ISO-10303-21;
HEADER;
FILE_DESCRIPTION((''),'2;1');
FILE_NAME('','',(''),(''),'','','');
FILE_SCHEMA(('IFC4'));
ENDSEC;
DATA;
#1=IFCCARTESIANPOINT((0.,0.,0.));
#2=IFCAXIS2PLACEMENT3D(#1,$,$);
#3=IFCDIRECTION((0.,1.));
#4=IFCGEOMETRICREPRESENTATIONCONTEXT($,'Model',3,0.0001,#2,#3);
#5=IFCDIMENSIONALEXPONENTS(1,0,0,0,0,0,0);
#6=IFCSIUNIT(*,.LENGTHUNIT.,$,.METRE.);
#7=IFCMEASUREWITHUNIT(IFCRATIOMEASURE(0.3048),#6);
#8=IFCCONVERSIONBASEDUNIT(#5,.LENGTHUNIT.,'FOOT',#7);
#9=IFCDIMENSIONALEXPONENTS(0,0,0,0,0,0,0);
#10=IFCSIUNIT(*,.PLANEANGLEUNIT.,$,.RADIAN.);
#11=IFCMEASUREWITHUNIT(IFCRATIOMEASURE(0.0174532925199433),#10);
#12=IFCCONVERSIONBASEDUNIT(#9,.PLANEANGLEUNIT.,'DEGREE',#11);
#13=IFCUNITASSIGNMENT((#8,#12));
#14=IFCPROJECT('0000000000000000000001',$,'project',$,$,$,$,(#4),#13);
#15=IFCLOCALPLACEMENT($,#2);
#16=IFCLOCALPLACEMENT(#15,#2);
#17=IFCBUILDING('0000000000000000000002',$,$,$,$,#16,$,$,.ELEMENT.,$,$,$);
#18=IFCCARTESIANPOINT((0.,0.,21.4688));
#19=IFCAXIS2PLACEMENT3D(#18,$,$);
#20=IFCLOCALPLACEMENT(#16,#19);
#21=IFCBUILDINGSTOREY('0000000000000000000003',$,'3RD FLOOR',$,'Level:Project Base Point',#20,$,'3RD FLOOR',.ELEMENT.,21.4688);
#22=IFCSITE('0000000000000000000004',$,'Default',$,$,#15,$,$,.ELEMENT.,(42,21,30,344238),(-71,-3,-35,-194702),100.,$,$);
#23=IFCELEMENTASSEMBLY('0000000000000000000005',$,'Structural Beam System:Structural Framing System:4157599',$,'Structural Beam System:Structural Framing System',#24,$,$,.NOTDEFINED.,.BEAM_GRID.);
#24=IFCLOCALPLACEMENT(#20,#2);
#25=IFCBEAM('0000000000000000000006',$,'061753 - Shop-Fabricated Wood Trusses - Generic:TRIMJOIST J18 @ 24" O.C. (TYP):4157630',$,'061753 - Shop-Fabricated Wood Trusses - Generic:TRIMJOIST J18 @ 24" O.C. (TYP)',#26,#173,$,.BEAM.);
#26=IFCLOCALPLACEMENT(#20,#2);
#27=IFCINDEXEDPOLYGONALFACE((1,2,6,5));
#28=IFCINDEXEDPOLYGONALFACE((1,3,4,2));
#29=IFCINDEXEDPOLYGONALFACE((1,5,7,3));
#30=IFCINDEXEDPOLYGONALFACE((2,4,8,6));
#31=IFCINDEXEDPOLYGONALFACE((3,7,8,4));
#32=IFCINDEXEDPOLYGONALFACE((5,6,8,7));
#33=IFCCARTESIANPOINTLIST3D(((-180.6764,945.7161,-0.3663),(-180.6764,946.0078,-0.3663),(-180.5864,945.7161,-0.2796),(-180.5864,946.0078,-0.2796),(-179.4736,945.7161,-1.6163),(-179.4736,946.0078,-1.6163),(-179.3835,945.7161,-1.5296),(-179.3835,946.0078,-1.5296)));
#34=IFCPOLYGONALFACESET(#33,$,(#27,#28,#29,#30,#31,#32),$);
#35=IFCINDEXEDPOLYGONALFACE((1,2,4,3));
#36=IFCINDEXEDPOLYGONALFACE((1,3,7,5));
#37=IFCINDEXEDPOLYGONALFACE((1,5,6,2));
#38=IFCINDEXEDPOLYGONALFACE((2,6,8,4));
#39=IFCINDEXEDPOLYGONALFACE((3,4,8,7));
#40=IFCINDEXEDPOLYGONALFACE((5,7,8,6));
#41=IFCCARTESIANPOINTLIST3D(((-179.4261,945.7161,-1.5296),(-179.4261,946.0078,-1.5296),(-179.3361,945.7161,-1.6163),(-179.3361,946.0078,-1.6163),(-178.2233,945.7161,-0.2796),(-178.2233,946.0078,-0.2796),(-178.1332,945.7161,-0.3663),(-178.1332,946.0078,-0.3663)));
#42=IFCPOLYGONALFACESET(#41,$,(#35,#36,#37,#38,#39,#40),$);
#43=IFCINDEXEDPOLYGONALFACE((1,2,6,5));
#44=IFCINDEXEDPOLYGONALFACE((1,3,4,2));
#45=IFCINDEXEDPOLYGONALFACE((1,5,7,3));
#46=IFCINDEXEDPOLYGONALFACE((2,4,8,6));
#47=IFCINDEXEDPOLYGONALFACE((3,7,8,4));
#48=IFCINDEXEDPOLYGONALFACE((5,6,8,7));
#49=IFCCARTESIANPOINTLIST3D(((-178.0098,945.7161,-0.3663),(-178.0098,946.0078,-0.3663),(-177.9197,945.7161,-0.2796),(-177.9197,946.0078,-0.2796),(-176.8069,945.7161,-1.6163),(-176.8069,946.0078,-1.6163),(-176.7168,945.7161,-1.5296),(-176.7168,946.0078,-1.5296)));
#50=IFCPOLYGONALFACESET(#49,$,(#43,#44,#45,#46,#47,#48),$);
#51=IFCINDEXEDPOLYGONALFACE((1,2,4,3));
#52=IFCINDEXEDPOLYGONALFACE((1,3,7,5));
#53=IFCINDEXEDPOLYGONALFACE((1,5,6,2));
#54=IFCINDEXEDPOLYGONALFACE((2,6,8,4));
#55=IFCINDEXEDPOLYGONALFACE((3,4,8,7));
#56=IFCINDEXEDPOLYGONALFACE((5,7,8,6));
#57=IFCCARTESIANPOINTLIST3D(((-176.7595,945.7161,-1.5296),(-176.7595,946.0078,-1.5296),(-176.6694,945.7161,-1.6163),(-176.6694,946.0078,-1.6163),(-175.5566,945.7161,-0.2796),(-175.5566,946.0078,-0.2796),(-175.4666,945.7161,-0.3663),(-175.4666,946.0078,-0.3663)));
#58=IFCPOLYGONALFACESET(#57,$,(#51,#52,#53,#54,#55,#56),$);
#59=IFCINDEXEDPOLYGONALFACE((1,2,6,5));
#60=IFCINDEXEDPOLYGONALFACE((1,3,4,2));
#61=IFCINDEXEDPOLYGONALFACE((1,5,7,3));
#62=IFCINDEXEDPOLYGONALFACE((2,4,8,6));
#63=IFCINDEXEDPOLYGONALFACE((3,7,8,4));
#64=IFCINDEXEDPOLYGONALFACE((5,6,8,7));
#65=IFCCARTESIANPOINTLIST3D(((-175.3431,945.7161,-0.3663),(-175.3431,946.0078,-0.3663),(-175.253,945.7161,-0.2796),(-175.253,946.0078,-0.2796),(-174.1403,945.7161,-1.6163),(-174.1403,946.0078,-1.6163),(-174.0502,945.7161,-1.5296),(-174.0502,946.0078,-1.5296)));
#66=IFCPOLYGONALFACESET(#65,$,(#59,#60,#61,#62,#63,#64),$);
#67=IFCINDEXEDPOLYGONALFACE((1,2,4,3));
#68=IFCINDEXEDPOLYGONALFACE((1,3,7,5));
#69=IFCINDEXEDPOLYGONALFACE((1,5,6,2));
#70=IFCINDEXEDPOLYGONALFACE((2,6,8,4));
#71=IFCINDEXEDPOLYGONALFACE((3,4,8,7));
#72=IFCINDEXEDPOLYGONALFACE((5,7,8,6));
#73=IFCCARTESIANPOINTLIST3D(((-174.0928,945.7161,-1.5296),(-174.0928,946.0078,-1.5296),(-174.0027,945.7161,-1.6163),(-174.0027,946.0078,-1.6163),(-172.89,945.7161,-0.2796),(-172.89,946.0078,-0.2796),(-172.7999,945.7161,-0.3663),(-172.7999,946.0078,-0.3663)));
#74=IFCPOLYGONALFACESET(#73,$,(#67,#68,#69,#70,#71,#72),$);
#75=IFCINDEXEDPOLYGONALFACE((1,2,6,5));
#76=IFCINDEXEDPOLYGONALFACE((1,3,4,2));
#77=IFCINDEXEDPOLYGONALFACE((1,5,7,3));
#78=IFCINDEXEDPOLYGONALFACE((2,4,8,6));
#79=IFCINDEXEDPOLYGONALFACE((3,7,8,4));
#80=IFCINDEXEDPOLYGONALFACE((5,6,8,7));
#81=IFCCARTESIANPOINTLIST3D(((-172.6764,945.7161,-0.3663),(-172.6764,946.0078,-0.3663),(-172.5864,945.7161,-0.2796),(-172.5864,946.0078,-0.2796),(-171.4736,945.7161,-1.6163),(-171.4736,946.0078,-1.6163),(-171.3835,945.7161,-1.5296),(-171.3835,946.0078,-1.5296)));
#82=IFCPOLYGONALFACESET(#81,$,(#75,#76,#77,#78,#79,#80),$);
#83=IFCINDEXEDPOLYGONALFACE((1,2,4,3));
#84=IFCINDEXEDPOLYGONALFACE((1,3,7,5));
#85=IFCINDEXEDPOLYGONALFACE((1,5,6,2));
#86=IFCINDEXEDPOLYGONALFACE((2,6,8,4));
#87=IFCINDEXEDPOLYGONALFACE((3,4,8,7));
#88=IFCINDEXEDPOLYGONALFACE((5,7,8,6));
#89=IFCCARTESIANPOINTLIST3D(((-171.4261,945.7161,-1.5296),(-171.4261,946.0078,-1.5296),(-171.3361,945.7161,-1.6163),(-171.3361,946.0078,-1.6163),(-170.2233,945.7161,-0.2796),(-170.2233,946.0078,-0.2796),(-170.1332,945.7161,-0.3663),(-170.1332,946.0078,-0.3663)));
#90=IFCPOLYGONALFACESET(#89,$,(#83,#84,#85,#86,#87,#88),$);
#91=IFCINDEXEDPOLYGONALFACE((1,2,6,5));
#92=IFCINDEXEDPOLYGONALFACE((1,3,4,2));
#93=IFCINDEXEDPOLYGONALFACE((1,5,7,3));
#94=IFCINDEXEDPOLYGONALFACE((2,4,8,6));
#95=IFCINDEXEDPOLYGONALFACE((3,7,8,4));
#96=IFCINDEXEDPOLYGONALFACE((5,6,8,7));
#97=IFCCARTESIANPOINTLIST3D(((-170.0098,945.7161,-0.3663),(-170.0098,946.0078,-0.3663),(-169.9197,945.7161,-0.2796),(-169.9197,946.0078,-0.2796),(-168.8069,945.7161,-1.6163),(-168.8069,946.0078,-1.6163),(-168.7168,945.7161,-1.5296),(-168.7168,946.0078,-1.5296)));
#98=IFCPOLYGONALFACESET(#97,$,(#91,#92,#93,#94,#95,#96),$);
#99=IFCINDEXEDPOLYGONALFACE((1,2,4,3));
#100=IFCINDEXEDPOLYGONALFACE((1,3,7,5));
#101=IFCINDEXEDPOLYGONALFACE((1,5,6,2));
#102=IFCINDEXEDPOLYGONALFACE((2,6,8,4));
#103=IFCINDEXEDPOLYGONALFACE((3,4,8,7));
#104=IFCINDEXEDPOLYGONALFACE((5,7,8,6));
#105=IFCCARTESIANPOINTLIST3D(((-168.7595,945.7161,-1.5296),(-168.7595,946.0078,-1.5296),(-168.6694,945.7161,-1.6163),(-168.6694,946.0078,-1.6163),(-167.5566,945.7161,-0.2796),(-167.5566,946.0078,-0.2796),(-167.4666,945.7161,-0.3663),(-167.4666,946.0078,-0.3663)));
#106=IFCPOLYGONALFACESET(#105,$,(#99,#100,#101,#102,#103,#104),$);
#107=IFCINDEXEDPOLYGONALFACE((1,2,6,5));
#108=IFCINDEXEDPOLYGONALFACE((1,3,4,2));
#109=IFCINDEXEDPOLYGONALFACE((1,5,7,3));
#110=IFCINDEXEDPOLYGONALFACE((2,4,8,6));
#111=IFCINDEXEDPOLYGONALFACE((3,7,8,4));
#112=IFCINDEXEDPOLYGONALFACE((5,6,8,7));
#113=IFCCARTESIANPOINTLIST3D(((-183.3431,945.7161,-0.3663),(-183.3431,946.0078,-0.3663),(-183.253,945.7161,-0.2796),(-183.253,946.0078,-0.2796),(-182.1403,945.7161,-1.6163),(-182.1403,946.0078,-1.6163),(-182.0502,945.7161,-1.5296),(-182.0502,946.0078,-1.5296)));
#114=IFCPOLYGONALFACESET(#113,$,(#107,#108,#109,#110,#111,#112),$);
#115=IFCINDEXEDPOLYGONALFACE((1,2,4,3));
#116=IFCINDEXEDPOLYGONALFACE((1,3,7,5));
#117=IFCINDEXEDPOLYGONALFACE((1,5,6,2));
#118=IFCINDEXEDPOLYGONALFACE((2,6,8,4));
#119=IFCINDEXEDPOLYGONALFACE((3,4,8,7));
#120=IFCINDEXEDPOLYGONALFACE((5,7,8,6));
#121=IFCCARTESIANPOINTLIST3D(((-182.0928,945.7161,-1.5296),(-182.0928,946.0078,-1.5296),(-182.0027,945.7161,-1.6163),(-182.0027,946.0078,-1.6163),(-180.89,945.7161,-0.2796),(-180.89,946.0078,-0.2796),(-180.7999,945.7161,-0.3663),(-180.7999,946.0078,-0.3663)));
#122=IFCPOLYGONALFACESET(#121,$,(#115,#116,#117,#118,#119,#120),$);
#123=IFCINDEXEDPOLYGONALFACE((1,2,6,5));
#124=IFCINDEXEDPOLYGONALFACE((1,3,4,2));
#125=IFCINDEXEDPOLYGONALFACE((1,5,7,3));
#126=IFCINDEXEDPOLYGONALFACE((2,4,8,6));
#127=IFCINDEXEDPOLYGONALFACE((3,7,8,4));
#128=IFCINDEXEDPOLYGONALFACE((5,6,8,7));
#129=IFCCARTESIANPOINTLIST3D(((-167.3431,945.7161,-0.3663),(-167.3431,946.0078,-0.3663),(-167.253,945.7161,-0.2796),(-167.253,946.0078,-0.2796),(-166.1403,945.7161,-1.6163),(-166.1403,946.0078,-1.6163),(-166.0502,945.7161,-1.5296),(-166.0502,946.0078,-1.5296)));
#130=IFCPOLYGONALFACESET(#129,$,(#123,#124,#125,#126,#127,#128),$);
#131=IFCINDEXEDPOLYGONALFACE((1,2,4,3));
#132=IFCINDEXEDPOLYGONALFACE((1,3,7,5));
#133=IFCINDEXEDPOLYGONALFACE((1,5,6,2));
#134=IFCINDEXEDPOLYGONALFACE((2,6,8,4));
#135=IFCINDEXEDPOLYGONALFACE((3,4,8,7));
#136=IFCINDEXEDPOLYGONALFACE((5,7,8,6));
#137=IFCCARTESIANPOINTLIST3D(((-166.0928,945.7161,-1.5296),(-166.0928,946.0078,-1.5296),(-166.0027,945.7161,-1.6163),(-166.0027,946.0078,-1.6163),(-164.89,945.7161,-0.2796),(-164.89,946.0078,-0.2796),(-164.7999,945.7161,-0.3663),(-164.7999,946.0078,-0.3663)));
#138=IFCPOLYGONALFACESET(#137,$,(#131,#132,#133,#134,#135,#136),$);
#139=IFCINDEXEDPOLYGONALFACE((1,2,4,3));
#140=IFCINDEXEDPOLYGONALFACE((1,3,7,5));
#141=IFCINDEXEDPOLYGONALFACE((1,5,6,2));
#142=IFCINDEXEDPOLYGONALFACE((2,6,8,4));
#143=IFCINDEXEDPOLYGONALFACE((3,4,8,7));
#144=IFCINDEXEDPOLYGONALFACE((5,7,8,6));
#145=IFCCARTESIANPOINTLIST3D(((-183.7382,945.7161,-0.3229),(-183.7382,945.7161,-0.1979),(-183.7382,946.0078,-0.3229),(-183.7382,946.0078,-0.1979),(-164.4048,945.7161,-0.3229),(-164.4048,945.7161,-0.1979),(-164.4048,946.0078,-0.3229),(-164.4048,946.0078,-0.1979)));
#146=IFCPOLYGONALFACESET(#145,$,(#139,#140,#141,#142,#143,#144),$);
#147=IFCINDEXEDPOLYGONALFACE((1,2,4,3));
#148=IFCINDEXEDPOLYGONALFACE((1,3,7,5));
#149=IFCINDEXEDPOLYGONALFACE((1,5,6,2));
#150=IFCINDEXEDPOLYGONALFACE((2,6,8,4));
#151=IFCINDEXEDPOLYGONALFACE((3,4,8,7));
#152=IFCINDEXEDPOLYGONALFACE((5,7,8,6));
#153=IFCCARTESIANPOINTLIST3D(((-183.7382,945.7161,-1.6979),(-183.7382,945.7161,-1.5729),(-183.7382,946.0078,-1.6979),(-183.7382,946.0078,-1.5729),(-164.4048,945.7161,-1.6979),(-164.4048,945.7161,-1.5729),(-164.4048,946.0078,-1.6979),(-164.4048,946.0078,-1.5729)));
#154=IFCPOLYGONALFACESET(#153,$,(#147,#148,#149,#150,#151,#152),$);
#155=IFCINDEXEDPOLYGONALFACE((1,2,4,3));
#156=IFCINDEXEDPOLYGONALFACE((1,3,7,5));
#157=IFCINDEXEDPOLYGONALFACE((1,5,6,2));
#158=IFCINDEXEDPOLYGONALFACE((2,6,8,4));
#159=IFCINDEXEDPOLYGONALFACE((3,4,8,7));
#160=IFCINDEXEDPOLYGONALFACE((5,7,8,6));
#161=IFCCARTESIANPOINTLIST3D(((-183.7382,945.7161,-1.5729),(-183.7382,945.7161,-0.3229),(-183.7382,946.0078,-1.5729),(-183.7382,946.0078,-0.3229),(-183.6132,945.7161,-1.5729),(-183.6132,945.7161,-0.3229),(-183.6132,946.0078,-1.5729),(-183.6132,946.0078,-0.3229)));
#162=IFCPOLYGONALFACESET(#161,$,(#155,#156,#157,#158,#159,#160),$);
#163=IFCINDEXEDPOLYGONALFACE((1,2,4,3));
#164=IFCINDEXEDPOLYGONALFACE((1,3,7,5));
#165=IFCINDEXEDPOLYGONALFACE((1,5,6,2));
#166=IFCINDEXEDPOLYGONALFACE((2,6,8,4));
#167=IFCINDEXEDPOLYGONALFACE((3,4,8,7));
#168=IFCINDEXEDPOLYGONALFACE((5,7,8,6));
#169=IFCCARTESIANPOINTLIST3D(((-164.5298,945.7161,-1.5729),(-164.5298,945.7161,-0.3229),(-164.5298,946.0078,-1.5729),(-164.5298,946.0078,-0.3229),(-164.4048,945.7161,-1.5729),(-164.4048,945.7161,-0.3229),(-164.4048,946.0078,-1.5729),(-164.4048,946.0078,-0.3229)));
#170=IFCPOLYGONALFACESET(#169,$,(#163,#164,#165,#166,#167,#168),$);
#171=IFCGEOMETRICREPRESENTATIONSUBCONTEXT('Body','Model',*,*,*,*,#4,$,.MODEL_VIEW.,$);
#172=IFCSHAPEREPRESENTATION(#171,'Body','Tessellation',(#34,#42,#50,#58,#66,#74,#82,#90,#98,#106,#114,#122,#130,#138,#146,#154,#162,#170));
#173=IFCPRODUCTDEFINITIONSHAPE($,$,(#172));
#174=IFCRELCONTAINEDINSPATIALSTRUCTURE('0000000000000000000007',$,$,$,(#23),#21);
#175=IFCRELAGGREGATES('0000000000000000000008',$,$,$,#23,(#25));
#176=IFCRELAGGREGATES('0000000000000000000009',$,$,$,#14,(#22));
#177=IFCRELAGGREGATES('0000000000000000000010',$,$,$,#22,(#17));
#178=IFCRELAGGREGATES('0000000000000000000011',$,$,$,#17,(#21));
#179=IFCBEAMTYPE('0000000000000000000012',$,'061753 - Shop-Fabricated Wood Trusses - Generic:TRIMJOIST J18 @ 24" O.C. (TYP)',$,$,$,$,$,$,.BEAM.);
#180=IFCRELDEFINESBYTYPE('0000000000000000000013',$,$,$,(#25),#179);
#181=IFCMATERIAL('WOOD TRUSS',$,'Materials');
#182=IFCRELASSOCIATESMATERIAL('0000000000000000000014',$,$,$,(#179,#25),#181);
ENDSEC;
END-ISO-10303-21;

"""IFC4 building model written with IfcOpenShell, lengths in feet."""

from ifc_helpers import new_model, entity, si_unit, converted_unit, direction, frame, frame_2d, origin, origin_2d_with_axis, place, context, subcontext, project, spatial, rectangle, extrude, source, transform, mapped, material, material_profile, profile_set, profile_usage, type_object, type_shapes, element, aggregate, save


model = new_model("IFC4")

# Units and contexts
model_context = context("Model", 3, precision=0.0001, world=origin(), true_north=direction((0.0, 1.0)))
body_context = subcontext(model_context, "Body", "Model", "MODEL_VIEW")
ifc_project = project(units=[converted_unit("LENGTHUNIT", "FOOT", entity("IfcRatioMeasure", 0.3048), si_unit("LENGTHUNIT", "METRE"), dimensions=[1, 0, 0, 0, 0, 0, 0]), converted_unit("PLANEANGLEUNIT", "DEGREE", entity("IfcRatioMeasure", 0.0174532925199433), si_unit("PLANEANGLEUNIT", "RADIAN"), dimensions=[0, 0, 0, 0, 0, 0, 0])], contexts=[model_context])

# Site, building, storey
site_placement = place(None, origin())
site = spatial("IfcSite", under=ifc_project, at=site_placement, Name="Default", CompositionType="ELEMENT", RefLatitude=(42, 21, 30, 344238), RefLongitude=(-71, -3, -35, -194702), RefElevation=100.0)
building_placement = place(site_placement, origin())
building = spatial("IfcBuilding", under=site, at=building_placement, CompositionType="ELEMENT")
storey_placement = place(building_placement, frame((0.0, 0.0, 21.4688)))
storey = spatial("IfcBuildingStorey", under=building, at=storey_placement, Name="3RD FLOOR", ObjectType="Level:Project Base Point", LongName="3RD FLOOR", CompositionType="ELEMENT", Elevation=21.4688)

# Element assembly, beam
ifc_material = material(Name="WOOD TRUSS", Category="Materials")
ifc_material_profile_1 = material_profile(ifc_material, rectangle(XDim=1.7347, YDim=0.125, at=frame_2d((0.0, 0.0), x_axis=(1.0, 0.0))), Name="TRIMJOIST J18 @ 24\" O.C. (TYP)")
ifc_material_profile_2 = material_profile(ifc_material, rectangle(XDim=1.7347, YDim=0.125, at=frame_2d((0.0, 0.0), x_axis=(1.0, 0.0))), Name="TRIMJOIST J18 @ 24\" O.C. (TYP)")
ifc_material_profile_3 = material_profile(ifc_material, rectangle(XDim=1.7347, YDim=0.125, at=frame_2d((0.0, 0.0), x_axis=(1.0, 0.0))), Name="TRIMJOIST J18 @ 24\" O.C. (TYP)")
ifc_material_profile_4 = material_profile(ifc_material, rectangle(XDim=1.7347, YDim=0.125, at=frame_2d((0.0, 0.0), x_axis=(1.0, 0.0))), Name="TRIMJOIST J18 @ 24\" O.C. (TYP)")
ifc_material_profile_5 = material_profile(ifc_material, rectangle(XDim=1.7347, YDim=0.125, at=frame_2d((0.0, 0.0), x_axis=(1.0, 0.0))), Name="TRIMJOIST J18 @ 24\" O.C. (TYP)")
ifc_material_profile_6 = material_profile(ifc_material, rectangle(XDim=1.7347, YDim=0.125, at=frame_2d((0.0, 0.0), x_axis=(1.0, 0.0))), Name="TRIMJOIST J18 @ 24\" O.C. (TYP)")
ifc_material_profile_7 = material_profile(ifc_material, rectangle(XDim=1.7347, YDim=0.125, at=frame_2d((0.0, 0.0), x_axis=(1.0, 0.0))), Name="TRIMJOIST J18 @ 24\" O.C. (TYP)")
ifc_material_profile_8 = material_profile(ifc_material, rectangle(XDim=1.7347, YDim=0.125, at=frame_2d((0.0, 0.0), x_axis=(1.0, 0.0))), Name="TRIMJOIST J18 @ 24\" O.C. (TYP)")
ifc_material_profile_9 = material_profile(ifc_material, rectangle(XDim=1.7347, YDim=0.125, at=frame_2d((0.0, 0.0), x_axis=(1.0, 0.0))), Name="TRIMJOIST J18 @ 24\" O.C. (TYP)")
ifc_material_profile_10 = material_profile(ifc_material, rectangle(XDim=1.7347, YDim=0.125, at=origin_2d_with_axis()), Name="TRIMJOIST J18 @ 24\" O.C. (TYP)")
ifc_material_profile_11 = material_profile(ifc_material, rectangle(XDim=0.125, YDim=0.2917, at=origin_2d_with_axis()), Name="TRIMJOIST J18 @ 24\" O.C. (TYP)")
ifc_material_profile_12 = material_profile(ifc_material, rectangle(XDim=0.125, YDim=0.2917, at=origin_2d_with_axis()), Name="TRIMJOIST J18 @ 24\" O.C. (TYP)")
ifc_material_profile_13 = material_profile(ifc_material, rectangle(XDim=1.25, YDim=0.2917, at=origin_2d_with_axis()), Name="TRIMJOIST J18 @ 24\" O.C. (TYP)")
ifc_material_profile_14 = material_profile(ifc_material, rectangle(XDim=1.25, YDim=0.2917, at=origin_2d_with_axis()), Name="TRIMJOIST J18 @ 24\" O.C. (TYP)")
ifc_profile_set = profile_set([ifc_material_profile_1, ifc_material_profile_2, ifc_material_profile_3, ifc_material_profile_4, ifc_material_profile_5, ifc_material_profile_6, ifc_material_profile_7, ifc_material_profile_8, ifc_material_profile_9, ifc_material_profile_10, ifc_material_profile_11, ifc_material_profile_12, ifc_material_profile_13, ifc_material_profile_14], Name="TRIMJOIST J18 @ 24\" O.C. (TYP)")
assembly_1_placement = place(storey_placement, origin())
assembly_1 = element("IfcElementAssembly", 1, at=assembly_1_placement, inside=storey, Name="Structural Beam System:Structural Framing System:4157599", ObjectType="Structural Beam System:Structural Framing System", AssemblyPlace="NOTDEFINED", PredefinedType="BEAM_GRID")
beam_type_1 = type_object("IfcBeamType", Name="061753 - Shop-Fabricated Wood Trusses - Generic:TRIMJOIST J18 @ 24\" O.C. (TYP)", PredefinedType="BEAM", material=ifc_profile_set)
shared_shape_1 = source(origin(), body_context, "Body", "SweptSolid", [
    extrude(rectangle(XDim=1.7347, YDim=0.125, at=frame_2d((0.0, 0.0), x_axis=(1.0, 0.0))), frame((5.9585, -0.1458, 0.0), z_axis=(0.0, 1.0, 0.0), x_axis=(0.693383, 0.0, 0.720569)), (0.0, 0.0, 1.0), 0.2917),
    extrude(rectangle(XDim=1.7347, YDim=0.125, at=origin_2d_with_axis()), frame((4.7082, -0.1458, 0.0), z_axis=(0.0, 1.0, 0.0), x_axis=(0.693383, 0.0, -0.720569)), (0.0, 0.0, 1.0), 0.2917),
    extrude(rectangle(XDim=1.7347, YDim=0.125, at=frame_2d((0.0, 0.0), x_axis=(1.0, 0.0))), frame((3.2918, -0.1458, 0.0), z_axis=(0.0, 1.0, 0.0), x_axis=(0.693383, 0.0, 0.720569)), (0.0, 0.0, 1.0), 0.2917),
    extrude(rectangle(XDim=1.7347, YDim=0.125, at=frame_2d((0.0, 0.0), x_axis=(1.0, 0.0))), frame((2.0415, -0.1458, 0.0), z_axis=(0.0, 1.0, 0.0), x_axis=(0.693383, 0.0, -0.720569)), (0.0, 0.0, 1.0), 0.2917),
    extrude(rectangle(XDim=1.7347, YDim=0.125, at=frame_2d((0.0, 0.0), x_axis=(1.0, 0.0))), frame((0.6251, -0.1458, 0.0), z_axis=(0.0, 1.0, 0.0), x_axis=(0.693383, 0.0, 0.720569)), (0.0, 0.0, 1.0), 0.2917),
    extrude(rectangle(XDim=1.7347, YDim=0.125, at=frame_2d((0.0, 0.0), x_axis=(1.0, 0.0))), frame((-0.6251, -0.1458, 0.0), z_axis=(0.0, 1.0, 0.0), x_axis=(0.693383, 0.0, -0.720569)), (0.0, 0.0, 1.0), 0.2917),
    extrude(rectangle(XDim=1.7347, YDim=0.125, at=frame_2d((0.0, 0.0), x_axis=(1.0, 0.0))), frame((-2.0415, -0.1458, 0.0), z_axis=(0.0, 1.0, 0.0), x_axis=(0.693383, 0.0, 0.720569)), (0.0, 0.0, 1.0), 0.2917),
    extrude(rectangle(XDim=1.7347, YDim=0.125, at=origin_2d_with_axis()), frame((-3.2918, -0.1458, 0.0), z_axis=(0.0, 1.0, 0.0), x_axis=(0.693383, 0.0, -0.720569)), (0.0, 0.0, 1.0), 0.2917),
    extrude(rectangle(XDim=1.7347, YDim=0.125, at=frame_2d((0.0, 0.0), x_axis=(1.0, 0.0))), frame((-4.7082, -0.1458, 0.0), z_axis=(0.0, 1.0, 0.0), x_axis=(0.693383, 0.0, 0.720569)), (0.0, 0.0, 1.0), 0.2917),
    extrude(rectangle(XDim=1.7347, YDim=0.125, at=frame_2d((0.0, 0.0), x_axis=(1.0, 0.0))), frame((-5.9585, -0.1458, 0.0), z_axis=(0.0, 1.0, 0.0), x_axis=(0.693383, 0.0, -0.720569)), (0.0, 0.0, 1.0), 0.2917),
    extrude(rectangle(XDim=1.7347, YDim=0.125, at=frame_2d((0.0, 0.0), x_axis=(1.0, 0.0))), frame((8.6251, -0.1458, 0.0), z_axis=(0.0, 1.0, 0.0), x_axis=(0.693383, 0.0, 0.720569)), (0.0, 0.0, 1.0), 0.2917),
    extrude(rectangle(XDim=1.7347, YDim=0.125, at=origin_2d_with_axis()), frame((7.3749, -0.1458, 0.0), z_axis=(0.0, 1.0, 0.0), x_axis=(0.693383, 0.0, -0.720569)), (0.0, 0.0, 1.0), 0.2917),
    extrude(rectangle(XDim=1.7347, YDim=0.125, at=frame_2d((0.0, 0.0), x_axis=(1.0, 0.0))), frame((-7.3749, -0.1458, 0.0), z_axis=(0.0, 1.0, 0.0), x_axis=(0.693383, 0.0, 0.720569)), (0.0, 0.0, 1.0), 0.2917),
    extrude(rectangle(XDim=1.7347, YDim=0.125, at=origin_2d_with_axis()), frame((-8.6251, -0.1458, 0.0), z_axis=(0.0, 1.0, 0.0), x_axis=(0.693383, 0.0, -0.720569)), (0.0, 0.0, 1.0), 0.2917),
    extrude(rectangle(XDim=0.125, YDim=0.2917, at=origin_2d_with_axis()), frame((-9.6667, 0.0, 0.6875), z_axis=(1.0, 0.0, 0.0), x_axis=(0.0, 0.0, -1.0)), (0.0, 0.0, 1.0), 19.3333),
    extrude(rectangle(XDim=0.125, YDim=0.2917, at=origin_2d_with_axis()), frame((-9.6667, 0.0, -0.6875), z_axis=(1.0, 0.0, 0.0), x_axis=(0.0, 0.0, -1.0)), (0.0, 0.0, 1.0), 19.3333),
    extrude(rectangle(XDim=1.25, YDim=0.2917, at=origin_2d_with_axis()), frame((9.5417, 0.0, 0.0), z_axis=(1.0, 0.0, 0.0), x_axis=(0.0, 0.0, -1.0)), (0.0, 0.0, 1.0), 0.125),
    extrude(rectangle(XDim=1.25, YDim=0.2917, at=origin_2d_with_axis()), frame((-9.6667, 0.0, 0.0), z_axis=(1.0, 0.0, 0.0), x_axis=(0.0, 0.0, -1.0)), (0.0, 0.0, 1.0), 0.125),
])
type_shapes(beam_type_1, [shared_shape_1])
ifc_profile_usage_1 = profile_usage(ifc_profile_set, cardinal=8)
beam_1_placement = place(assembly_1_placement, frame((-174.0715, 945.8619, -0.9479), z_axis=(0.0, 0.0, 1.0), x_axis=(-1.0, 0.0, 0.0)))
beam_1 = element("IfcBeam", 2, at=beam_1_placement, type_object=beam_type_1, material=ifc_profile_usage_1, Name="061753 - Shop-Fabricated Wood Trusses - Generic:TRIMJOIST J18 @ 24\" O.C. (TYP):4157630", ObjectType="061753 - Shop-Fabricated Wood Trusses - Generic:TRIMJOIST J18 @ 24\" O.C. (TYP)", PredefinedType="BEAM", context=body_context, shape_type="MappedRepresentation", body=[
    mapped(shared_shape_1, transform((0.0, 0.0, 0.0), scale=1.0)),
])
aggregate(assembly_1, [beam_1])

save(model, "model.ifc")
